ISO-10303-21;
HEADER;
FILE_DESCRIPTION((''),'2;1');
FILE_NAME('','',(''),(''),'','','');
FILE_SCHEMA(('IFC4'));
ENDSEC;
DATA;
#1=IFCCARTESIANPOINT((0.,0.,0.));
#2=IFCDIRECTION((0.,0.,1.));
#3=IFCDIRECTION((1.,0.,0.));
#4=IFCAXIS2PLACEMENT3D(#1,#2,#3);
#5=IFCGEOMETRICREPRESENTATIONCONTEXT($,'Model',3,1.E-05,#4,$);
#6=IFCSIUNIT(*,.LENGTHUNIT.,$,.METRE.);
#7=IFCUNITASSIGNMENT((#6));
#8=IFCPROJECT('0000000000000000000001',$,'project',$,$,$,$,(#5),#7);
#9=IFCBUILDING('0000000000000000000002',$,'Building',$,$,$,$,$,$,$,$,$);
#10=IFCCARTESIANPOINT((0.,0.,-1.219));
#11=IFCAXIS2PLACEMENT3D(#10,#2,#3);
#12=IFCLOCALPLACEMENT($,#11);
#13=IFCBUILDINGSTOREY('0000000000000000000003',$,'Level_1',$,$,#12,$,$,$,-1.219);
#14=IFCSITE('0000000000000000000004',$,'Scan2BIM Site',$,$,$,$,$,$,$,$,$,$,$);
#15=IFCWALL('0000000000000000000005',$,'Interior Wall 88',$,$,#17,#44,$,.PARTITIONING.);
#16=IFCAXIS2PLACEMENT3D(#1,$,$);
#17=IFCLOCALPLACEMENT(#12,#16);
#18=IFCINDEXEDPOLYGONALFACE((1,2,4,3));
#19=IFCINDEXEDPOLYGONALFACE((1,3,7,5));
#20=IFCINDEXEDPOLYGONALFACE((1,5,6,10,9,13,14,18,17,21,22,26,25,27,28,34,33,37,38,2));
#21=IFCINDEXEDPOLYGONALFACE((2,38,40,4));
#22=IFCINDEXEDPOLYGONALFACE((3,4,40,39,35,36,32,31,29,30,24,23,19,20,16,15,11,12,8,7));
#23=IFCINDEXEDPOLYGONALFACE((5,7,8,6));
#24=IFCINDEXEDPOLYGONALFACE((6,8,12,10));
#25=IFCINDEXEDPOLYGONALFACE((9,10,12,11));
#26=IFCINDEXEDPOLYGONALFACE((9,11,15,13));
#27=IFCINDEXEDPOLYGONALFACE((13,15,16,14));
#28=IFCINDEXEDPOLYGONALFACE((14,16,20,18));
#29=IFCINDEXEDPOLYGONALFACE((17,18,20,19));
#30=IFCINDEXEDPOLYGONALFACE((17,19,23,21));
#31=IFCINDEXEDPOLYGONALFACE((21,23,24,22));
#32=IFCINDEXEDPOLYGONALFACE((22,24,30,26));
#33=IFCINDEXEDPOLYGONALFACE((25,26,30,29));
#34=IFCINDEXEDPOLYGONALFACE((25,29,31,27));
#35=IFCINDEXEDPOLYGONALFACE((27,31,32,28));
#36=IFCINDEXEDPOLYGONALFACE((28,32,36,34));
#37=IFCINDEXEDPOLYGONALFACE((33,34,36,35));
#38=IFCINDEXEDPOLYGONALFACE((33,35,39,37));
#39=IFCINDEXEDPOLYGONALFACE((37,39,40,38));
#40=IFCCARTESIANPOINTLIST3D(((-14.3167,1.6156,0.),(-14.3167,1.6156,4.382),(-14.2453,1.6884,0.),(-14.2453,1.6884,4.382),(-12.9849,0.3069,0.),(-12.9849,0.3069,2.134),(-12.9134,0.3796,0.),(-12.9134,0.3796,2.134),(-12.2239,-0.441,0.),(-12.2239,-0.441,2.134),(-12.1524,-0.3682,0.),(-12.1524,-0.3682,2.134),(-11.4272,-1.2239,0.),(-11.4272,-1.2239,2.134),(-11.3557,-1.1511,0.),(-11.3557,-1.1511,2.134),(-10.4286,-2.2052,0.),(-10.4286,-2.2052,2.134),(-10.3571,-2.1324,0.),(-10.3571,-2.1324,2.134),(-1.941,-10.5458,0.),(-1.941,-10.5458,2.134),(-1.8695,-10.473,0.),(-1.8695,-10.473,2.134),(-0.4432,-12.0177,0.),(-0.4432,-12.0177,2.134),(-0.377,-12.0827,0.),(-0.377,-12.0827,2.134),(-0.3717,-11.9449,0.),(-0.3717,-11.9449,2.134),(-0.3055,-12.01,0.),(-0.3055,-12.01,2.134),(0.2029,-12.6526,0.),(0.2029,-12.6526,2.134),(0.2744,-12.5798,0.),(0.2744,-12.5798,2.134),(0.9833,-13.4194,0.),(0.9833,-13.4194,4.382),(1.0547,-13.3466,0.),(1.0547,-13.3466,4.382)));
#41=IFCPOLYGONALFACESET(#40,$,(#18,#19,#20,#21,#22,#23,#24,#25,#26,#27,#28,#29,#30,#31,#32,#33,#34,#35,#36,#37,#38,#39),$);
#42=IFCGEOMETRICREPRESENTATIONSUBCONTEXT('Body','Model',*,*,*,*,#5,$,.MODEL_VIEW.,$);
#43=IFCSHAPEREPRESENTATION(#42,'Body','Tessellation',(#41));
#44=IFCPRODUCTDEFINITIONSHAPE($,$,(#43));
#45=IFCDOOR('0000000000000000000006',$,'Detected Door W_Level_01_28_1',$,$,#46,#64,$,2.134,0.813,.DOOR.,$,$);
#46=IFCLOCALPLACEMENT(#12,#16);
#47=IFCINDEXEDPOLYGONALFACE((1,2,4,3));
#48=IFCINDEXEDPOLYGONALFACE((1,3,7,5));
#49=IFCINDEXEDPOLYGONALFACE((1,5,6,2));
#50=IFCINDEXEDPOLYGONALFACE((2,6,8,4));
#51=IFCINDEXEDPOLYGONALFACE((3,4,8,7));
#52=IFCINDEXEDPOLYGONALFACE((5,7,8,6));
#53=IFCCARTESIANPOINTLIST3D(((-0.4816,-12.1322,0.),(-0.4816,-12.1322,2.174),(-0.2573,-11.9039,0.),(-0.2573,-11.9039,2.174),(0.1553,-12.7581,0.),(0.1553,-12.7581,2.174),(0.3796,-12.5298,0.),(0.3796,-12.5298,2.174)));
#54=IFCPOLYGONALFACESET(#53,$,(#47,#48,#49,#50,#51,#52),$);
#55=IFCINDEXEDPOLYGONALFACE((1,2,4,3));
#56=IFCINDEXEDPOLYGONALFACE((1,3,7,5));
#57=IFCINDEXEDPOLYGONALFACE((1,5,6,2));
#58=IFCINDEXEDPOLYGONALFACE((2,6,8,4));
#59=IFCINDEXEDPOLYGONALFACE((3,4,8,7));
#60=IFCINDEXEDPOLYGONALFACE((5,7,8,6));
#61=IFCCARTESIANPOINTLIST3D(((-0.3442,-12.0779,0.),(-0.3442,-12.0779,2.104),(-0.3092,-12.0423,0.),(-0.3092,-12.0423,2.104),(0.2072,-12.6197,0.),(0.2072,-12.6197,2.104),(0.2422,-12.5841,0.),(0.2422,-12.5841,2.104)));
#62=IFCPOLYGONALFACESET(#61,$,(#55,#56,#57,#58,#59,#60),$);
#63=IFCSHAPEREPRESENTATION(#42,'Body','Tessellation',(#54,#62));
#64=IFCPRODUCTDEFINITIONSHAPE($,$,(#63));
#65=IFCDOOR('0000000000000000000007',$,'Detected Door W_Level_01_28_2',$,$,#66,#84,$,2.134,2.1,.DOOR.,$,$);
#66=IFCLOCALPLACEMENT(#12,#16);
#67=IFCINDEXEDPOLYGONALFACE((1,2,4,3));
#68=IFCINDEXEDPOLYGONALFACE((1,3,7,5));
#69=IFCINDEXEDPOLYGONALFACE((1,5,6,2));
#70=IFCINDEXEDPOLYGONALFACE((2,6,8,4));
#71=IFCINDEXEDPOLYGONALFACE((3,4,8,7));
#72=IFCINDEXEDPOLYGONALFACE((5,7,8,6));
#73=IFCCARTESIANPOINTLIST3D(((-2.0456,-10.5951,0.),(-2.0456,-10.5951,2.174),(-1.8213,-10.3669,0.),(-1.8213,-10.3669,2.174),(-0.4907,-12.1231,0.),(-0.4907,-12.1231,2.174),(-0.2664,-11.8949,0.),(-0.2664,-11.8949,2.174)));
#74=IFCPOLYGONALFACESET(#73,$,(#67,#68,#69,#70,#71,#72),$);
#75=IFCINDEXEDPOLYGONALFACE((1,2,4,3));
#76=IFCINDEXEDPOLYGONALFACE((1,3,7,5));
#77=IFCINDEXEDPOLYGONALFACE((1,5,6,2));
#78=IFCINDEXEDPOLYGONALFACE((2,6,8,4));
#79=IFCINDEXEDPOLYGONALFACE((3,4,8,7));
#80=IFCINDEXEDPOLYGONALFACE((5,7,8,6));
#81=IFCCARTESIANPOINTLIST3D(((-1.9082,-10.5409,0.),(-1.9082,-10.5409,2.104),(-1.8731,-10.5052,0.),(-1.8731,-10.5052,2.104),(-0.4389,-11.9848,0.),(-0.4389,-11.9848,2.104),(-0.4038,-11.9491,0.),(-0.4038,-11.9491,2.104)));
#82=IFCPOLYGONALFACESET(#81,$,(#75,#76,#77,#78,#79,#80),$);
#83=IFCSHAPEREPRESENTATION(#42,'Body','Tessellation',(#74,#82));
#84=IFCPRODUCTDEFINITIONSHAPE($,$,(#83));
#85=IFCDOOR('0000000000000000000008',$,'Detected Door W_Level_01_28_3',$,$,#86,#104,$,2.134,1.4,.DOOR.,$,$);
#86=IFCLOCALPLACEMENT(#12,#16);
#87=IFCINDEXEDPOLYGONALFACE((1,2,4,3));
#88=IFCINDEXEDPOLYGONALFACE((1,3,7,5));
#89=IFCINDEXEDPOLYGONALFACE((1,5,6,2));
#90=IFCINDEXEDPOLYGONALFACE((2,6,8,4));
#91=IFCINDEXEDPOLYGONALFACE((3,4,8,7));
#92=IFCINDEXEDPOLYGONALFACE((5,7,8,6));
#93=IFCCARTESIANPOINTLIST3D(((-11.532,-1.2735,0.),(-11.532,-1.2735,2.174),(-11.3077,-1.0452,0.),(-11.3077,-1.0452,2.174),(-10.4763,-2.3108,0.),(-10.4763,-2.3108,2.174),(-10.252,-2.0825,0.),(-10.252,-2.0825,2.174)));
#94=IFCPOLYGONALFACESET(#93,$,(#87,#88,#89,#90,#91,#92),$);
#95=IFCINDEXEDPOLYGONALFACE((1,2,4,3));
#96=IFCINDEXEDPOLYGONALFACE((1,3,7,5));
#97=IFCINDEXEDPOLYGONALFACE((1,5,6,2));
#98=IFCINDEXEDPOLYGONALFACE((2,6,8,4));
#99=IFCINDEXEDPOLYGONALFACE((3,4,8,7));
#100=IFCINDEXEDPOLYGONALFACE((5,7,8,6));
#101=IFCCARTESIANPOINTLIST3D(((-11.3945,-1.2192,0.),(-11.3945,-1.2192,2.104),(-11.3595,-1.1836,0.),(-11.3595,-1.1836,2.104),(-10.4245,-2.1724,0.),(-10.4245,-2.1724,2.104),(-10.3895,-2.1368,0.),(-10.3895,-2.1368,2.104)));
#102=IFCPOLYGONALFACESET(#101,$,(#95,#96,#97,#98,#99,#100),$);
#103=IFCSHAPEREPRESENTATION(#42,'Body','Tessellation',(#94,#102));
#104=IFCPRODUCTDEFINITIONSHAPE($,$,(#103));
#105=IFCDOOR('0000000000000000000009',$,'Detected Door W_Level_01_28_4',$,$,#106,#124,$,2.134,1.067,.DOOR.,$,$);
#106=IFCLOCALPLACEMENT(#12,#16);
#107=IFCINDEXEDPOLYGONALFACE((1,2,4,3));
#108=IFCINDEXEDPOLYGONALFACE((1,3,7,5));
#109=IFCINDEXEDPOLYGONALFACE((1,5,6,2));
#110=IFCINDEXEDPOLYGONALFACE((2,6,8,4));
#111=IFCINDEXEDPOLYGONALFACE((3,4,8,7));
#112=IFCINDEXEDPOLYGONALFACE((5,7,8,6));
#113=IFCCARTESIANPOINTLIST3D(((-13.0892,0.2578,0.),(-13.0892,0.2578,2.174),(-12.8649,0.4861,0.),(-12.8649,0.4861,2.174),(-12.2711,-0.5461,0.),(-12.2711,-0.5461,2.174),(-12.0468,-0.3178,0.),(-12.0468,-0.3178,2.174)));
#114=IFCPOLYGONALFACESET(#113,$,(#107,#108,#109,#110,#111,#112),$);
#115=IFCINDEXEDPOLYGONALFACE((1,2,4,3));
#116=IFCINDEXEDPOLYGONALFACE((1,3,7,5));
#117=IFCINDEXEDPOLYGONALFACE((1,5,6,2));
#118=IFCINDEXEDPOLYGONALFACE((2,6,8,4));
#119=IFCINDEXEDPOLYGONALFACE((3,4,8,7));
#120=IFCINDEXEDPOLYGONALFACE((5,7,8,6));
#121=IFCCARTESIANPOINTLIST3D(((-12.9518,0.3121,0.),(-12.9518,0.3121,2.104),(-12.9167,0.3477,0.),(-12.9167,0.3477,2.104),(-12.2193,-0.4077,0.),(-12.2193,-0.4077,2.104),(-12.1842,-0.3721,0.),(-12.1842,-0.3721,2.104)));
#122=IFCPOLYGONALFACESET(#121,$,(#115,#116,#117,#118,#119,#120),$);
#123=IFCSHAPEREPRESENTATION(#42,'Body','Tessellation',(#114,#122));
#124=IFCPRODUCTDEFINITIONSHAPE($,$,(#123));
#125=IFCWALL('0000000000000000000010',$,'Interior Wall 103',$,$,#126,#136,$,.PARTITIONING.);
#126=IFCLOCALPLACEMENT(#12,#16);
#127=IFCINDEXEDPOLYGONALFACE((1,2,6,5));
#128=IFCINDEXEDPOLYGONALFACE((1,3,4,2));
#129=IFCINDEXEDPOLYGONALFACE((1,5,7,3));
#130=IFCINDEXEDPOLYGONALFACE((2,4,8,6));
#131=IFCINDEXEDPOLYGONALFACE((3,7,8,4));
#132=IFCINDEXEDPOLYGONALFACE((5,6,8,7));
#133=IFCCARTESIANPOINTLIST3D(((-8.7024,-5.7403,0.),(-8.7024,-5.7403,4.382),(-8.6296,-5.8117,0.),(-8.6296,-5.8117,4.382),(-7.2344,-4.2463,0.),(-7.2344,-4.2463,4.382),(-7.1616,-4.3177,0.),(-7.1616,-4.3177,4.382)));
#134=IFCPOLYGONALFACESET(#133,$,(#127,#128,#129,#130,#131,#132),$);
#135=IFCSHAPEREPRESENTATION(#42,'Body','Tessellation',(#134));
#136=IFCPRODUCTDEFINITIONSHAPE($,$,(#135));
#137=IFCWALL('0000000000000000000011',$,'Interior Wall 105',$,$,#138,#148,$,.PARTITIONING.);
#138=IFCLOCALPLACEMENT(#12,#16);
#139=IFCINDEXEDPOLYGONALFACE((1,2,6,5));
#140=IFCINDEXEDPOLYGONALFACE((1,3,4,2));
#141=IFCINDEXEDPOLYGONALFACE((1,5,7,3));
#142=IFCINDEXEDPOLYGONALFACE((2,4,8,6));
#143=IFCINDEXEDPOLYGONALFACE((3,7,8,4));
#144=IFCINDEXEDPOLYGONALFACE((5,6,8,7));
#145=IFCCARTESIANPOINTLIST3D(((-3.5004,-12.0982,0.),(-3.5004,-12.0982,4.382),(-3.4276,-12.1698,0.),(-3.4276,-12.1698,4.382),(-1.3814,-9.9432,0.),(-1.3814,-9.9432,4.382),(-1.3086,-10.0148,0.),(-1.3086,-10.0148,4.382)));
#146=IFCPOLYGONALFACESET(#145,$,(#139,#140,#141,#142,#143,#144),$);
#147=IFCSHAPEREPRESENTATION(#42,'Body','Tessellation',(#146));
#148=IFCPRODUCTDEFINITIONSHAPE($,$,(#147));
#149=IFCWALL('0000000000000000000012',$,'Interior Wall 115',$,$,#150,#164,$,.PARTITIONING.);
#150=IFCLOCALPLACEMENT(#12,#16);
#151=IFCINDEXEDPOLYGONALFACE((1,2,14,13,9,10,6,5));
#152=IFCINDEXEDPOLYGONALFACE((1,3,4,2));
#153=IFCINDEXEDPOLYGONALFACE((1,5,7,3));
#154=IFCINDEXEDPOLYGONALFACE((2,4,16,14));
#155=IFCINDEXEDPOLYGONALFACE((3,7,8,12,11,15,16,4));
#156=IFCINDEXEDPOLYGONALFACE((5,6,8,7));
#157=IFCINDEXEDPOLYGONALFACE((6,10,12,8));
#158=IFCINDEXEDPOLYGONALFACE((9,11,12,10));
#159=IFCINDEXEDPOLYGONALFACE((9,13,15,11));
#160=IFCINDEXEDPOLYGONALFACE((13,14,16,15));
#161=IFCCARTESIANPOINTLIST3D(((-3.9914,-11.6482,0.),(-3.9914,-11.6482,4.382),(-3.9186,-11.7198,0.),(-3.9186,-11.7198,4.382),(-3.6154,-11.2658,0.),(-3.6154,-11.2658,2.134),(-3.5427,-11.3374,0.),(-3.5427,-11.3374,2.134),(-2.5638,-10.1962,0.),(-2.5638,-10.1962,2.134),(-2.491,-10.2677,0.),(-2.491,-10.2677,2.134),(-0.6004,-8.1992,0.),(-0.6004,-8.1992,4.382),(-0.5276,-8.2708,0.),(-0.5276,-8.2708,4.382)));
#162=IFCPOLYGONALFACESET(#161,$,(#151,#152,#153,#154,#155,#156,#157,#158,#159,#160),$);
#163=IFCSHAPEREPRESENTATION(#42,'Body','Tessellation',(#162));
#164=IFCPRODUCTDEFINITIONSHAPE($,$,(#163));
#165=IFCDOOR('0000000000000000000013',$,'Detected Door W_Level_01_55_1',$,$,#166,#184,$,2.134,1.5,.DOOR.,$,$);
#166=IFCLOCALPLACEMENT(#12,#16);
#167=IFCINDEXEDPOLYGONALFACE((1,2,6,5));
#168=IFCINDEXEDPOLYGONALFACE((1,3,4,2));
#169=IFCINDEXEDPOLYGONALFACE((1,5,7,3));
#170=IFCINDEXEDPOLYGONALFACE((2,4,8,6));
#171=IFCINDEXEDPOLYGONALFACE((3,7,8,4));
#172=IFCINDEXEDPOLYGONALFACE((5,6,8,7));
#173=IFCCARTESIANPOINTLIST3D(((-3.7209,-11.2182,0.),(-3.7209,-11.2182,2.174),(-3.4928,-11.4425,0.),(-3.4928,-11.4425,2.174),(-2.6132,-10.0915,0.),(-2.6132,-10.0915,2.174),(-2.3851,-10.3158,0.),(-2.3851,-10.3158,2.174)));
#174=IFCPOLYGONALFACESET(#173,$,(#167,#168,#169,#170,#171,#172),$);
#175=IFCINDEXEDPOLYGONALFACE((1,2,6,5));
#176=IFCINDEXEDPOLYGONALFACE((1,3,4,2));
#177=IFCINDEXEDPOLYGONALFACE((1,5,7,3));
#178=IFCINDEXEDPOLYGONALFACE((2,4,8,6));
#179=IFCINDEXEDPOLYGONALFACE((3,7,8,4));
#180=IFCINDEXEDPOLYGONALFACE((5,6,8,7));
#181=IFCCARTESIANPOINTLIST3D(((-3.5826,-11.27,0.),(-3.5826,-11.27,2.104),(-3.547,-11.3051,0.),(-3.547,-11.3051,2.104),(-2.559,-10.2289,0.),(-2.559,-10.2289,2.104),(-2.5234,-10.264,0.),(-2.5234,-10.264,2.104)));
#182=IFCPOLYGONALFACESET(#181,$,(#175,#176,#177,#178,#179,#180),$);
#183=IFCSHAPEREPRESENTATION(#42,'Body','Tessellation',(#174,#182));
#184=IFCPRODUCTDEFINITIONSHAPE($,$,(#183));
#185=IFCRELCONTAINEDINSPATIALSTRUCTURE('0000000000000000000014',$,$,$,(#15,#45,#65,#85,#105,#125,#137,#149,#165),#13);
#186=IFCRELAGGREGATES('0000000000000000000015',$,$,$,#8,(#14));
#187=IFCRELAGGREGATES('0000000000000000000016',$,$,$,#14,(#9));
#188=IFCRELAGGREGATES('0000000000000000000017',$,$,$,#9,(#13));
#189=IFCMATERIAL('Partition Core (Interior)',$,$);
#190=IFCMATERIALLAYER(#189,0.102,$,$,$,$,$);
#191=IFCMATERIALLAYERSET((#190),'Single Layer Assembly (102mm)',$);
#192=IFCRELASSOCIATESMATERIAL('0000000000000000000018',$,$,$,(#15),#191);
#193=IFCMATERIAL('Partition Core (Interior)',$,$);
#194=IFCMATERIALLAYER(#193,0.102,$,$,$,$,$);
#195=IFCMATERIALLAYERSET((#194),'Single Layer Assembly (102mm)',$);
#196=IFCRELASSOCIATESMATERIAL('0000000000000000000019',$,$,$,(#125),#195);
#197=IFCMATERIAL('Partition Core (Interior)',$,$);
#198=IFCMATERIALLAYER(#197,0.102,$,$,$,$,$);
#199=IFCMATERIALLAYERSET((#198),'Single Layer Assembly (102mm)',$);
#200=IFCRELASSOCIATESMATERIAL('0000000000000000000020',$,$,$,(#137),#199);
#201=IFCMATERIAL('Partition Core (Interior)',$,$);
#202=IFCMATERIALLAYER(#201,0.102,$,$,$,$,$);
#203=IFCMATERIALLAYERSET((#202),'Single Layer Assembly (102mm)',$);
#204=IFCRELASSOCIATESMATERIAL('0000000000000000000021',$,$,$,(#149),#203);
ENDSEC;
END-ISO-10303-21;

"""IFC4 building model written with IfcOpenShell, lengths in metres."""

from ifc_helpers import new_model, si_unit, frame, origin, origin_with_axes, place, context, subcontext, project, spatial, rectangle, extrude, material, layer, layer_set, element, fill, save


model = new_model("IFC4")

# Units and contexts
model_context = context("Model", 3, precision=1e-05, world=origin_with_axes())
body_context = subcontext(model_context, "Body", "Model", "MODEL_VIEW")
ifc_project = project(units=[si_unit("LENGTHUNIT", "METRE")], contexts=[model_context])

# Site, building, storey
site = spatial("IfcSite", under=ifc_project, Name="Scan2BIM Site")
building = spatial("IfcBuilding", under=site, Name="Building")
storey_placement = place(None, frame((0.0, 0.0, -1.219), z_axis=(0.0, 0.0, 1.0), x_axis=(1.0, 0.0, 0.0)))
storey = spatial("IfcBuildingStorey", under=building, at=storey_placement, Name="Level_1", Elevation=-1.219)

# Wall, openings, doors
ifc_material_1 = material(Name="Partition Core (Interior)")
ifc_layer_1 = layer(ifc_material_1, 0.102)
ifc_layer_set_1 = layer_set([ifc_layer_1], Name="Single Layer Assembly (102mm)")
wall_1_placement = place(storey_placement, frame((-6.631, -5.8655, 0.0), z_axis=(0.0, 0.0, 1.0), x_axis=(-0.713257, 0.700903, 0.0)))
wall_1 = element("IfcWall", 1, at=wall_1_placement, inside=storey, material=ifc_layer_set_1, Name="Interior Wall 88", PredefinedType="PARTITIONING", context=body_context, shape_type="SweptSolid", body=[
    extrude(rectangle(XDim=21.4509, YDim=0.102), origin(), (0.0, 0.0, 1.0), 4.382),
])
opening_1_placement = place(None, frame((-0.051, -12.331, -1.219), z_axis=(0.0, 0.0, 1.0), x_axis=(-0.713257, 0.700903, 0.0)))
opening_1 = element("IfcOpeningElement", 2, at=opening_1_placement, cuts=wall_1, PredefinedType="OPENING", context=body_context, shape_type="SweptSolid", body=[
    extrude(rectangle(XDim=0.813, YDim=0.202), origin(), (0.0, 0.0, 1.0), 2.134),
])
opening_2_placement = place(None, frame((-1.156, -11.245, -1.219), z_axis=(0.0, 0.0, 1.0), x_axis=(-0.713257, 0.700903, 0.0)))
opening_2 = element("IfcOpeningElement", 3, at=opening_2_placement, cuts=wall_1, PredefinedType="OPENING", context=body_context, shape_type="SweptSolid", body=[
    extrude(rectangle(XDim=2.1, YDim=0.202), origin(), (0.0, 0.0, 1.0), 2.134),
])
opening_3_placement = place(None, frame((-10.892, -1.678, -1.219), z_axis=(0.0, 0.0, 1.0), x_axis=(-0.713257, 0.700903, 0.0)))
opening_3 = element("IfcOpeningElement", 4, at=opening_3_placement, cuts=wall_1, PredefinedType="OPENING", context=body_context, shape_type="SweptSolid", body=[
    extrude(rectangle(XDim=1.4, YDim=0.202), origin(), (0.0, 0.0, 1.0), 2.134),
])
opening_4_placement = place(None, frame((-12.568, -0.03, -1.219), z_axis=(0.0, 0.0, 1.0), x_axis=(-0.713257, 0.700903, 0.0)))
opening_4 = element("IfcOpeningElement", 5, at=opening_4_placement, cuts=wall_1, PredefinedType="OPENING", context=body_context, shape_type="SweptSolid", body=[
    extrude(rectangle(XDim=1.067, YDim=0.202), origin(), (0.0, 0.0, 1.0), 2.134),
])
door_1_placement = place(opening_1_placement, frame((0.0, 0.0, 0.0), z_axis=(0.0, 0.0, 1.0), x_axis=(1.0, 0.0, 0.0)))
door_1 = element("IfcDoor", 6, at=door_1_placement, inside=storey, Name="Detected Door W_Level_01_28_1", OverallHeight=2.134, OverallWidth=0.813, PredefinedType="DOOR", context=body_context, shape_type="SweptSolid", body=[
    extrude(rectangle(XDim=0.893, YDim=0.32), origin(), (0.0, 0.0, 1.0), 2.174),
    extrude(rectangle(XDim=0.773, YDim=0.05), origin(), (0.0, 0.0, 1.0), 2.104),
])
fill(opening_1, door_1)
door_2_placement = place(opening_2_placement, frame((0.0, 0.0, 0.0), z_axis=(0.0, 0.0, 1.0), x_axis=(1.0, 0.0, 0.0)))
door_2 = element("IfcDoor", 7, at=door_2_placement, inside=storey, Name="Detected Door W_Level_01_28_2", OverallHeight=2.134, OverallWidth=2.1, PredefinedType="DOOR", context=body_context, shape_type="SweptSolid", body=[
    extrude(rectangle(XDim=2.18, YDim=0.32), origin(), (0.0, 0.0, 1.0), 2.174),
    extrude(rectangle(XDim=2.06, YDim=0.05), origin(), (0.0, 0.0, 1.0), 2.104),
])
fill(opening_2, door_2)
door_3_placement = place(opening_3_placement, frame((0.0, 0.0, 0.0), z_axis=(0.0, 0.0, 1.0), x_axis=(1.0, 0.0, 0.0)))
door_3 = element("IfcDoor", 8, at=door_3_placement, inside=storey, Name="Detected Door W_Level_01_28_3", OverallHeight=2.134, OverallWidth=1.4, PredefinedType="DOOR", context=body_context, shape_type="SweptSolid", body=[
    extrude(rectangle(XDim=1.48, YDim=0.32), origin(), (0.0, 0.0, 1.0), 2.174),
    extrude(rectangle(XDim=1.36, YDim=0.05), origin(), (0.0, 0.0, 1.0), 2.104),
])
fill(opening_3, door_3)
door_4_placement = place(opening_4_placement, frame((0.0, 0.0, 0.0), z_axis=(0.0, 0.0, 1.0), x_axis=(1.0, 0.0, 0.0)))
door_4 = element("IfcDoor", 9, at=door_4_placement, inside=storey, Name="Detected Door W_Level_01_28_4", OverallHeight=2.134, OverallWidth=1.067, PredefinedType="DOOR", context=body_context, shape_type="SweptSolid", body=[
    extrude(rectangle(XDim=1.147, YDim=0.32), origin(), (0.0, 0.0, 1.0), 2.174),
    extrude(rectangle(XDim=1.027, YDim=0.05), origin(), (0.0, 0.0, 1.0), 2.104),
])
fill(opening_4, door_4)

# Walls
ifc_material_2 = material(Name="Partition Core (Interior)")
ifc_layer_2 = layer(ifc_material_2, 0.102)
ifc_layer_set_2 = layer_set([ifc_layer_2], Name="Single Layer Assembly (102mm)")
wall_2_placement = place(storey_placement, frame((-7.932, -5.029, 0.0), z_axis=(0.0, 0.0, 1.0), x_axis=(-0.700873, -0.713286, 0.0)))
element("IfcWall", 10, at=wall_2_placement, inside=storey, material=ifc_layer_set_2, Name="Interior Wall 103", PredefinedType="PARTITIONING", context=body_context, shape_type="SweptSolid", body=[
    extrude(rectangle(XDim=2.0945, YDim=0.102), origin(), (0.0, 0.0, 1.0), 4.382),
])
ifc_material_3 = material(Name="Partition Core (Interior)")
ifc_layer_3 = layer(ifc_material_3, 0.102)
ifc_layer_set_3 = layer_set([ifc_layer_3], Name="Single Layer Assembly (102mm)")
wall_3_placement = place(storey_placement, frame((-2.4045, -11.0565, 0.0), z_axis=(0.0, 0.0, 1.0), x_axis=(0.701126, 0.713037, 0.0)))
element("IfcWall", 11, at=wall_3_placement, inside=storey, material=ifc_layer_set_3, Name="Interior Wall 105", PredefinedType="PARTITIONING", context=body_context, shape_type="SweptSolid", body=[
    extrude(rectangle(XDim=3.0223, YDim=0.102), origin(), (0.0, 0.0, 1.0), 4.382),
])

# Wall, opening, door
ifc_material_4 = material(Name="Partition Core (Interior)")
ifc_layer_4 = layer(ifc_material_4, 0.102)
ifc_layer_set_4 = layer_set([ifc_layer_4], Name="Single Layer Assembly (102mm)")
wall_4_placement = place(storey_placement, frame((-2.2595, -9.9595, 0.0), z_axis=(0.0, 0.0, 1.0), x_axis=(-0.701086, -0.713077, 0.0)))
wall_4 = element("IfcWall", 12, at=wall_4_placement, inside=storey, material=ifc_layer_set_4, Name="Interior Wall 115", PredefinedType="PARTITIONING", context=body_context, shape_type="SweptSolid", body=[
    extrude(rectangle(XDim=4.8368, YDim=0.102), origin(), (0.0, 0.0, 1.0), 4.382),
])
opening_5_placement = place(None, frame((-3.053, -10.767, -1.219), z_axis=(0.0, 0.0, 1.0), x_axis=(-0.701086, -0.713077, 0.0)))
opening_5 = element("IfcOpeningElement", 13, at=opening_5_placement, cuts=wall_4, PredefinedType="OPENING", context=body_context, shape_type="SweptSolid", body=[
    extrude(rectangle(XDim=1.5, YDim=0.202), origin(), (0.0, 0.0, 1.0), 2.134),
])
door_5_placement = place(opening_5_placement, frame((0.0, 0.0, 0.0), z_axis=(0.0, 0.0, 1.0), x_axis=(1.0, 0.0, 0.0)))
door_5 = element("IfcDoor", 14, at=door_5_placement, inside=storey, Name="Detected Door W_Level_01_55_1", OverallHeight=2.134, OverallWidth=1.5, PredefinedType="DOOR", context=body_context, shape_type="SweptSolid", body=[
    extrude(rectangle(XDim=1.58, YDim=0.32), origin(), (0.0, 0.0, 1.0), 2.174),
    extrude(rectangle(XDim=1.46, YDim=0.05), origin(), (0.0, 0.0, 1.0), 2.104),
])
fill(opening_5, door_5)

save(model, "model.ifc")
